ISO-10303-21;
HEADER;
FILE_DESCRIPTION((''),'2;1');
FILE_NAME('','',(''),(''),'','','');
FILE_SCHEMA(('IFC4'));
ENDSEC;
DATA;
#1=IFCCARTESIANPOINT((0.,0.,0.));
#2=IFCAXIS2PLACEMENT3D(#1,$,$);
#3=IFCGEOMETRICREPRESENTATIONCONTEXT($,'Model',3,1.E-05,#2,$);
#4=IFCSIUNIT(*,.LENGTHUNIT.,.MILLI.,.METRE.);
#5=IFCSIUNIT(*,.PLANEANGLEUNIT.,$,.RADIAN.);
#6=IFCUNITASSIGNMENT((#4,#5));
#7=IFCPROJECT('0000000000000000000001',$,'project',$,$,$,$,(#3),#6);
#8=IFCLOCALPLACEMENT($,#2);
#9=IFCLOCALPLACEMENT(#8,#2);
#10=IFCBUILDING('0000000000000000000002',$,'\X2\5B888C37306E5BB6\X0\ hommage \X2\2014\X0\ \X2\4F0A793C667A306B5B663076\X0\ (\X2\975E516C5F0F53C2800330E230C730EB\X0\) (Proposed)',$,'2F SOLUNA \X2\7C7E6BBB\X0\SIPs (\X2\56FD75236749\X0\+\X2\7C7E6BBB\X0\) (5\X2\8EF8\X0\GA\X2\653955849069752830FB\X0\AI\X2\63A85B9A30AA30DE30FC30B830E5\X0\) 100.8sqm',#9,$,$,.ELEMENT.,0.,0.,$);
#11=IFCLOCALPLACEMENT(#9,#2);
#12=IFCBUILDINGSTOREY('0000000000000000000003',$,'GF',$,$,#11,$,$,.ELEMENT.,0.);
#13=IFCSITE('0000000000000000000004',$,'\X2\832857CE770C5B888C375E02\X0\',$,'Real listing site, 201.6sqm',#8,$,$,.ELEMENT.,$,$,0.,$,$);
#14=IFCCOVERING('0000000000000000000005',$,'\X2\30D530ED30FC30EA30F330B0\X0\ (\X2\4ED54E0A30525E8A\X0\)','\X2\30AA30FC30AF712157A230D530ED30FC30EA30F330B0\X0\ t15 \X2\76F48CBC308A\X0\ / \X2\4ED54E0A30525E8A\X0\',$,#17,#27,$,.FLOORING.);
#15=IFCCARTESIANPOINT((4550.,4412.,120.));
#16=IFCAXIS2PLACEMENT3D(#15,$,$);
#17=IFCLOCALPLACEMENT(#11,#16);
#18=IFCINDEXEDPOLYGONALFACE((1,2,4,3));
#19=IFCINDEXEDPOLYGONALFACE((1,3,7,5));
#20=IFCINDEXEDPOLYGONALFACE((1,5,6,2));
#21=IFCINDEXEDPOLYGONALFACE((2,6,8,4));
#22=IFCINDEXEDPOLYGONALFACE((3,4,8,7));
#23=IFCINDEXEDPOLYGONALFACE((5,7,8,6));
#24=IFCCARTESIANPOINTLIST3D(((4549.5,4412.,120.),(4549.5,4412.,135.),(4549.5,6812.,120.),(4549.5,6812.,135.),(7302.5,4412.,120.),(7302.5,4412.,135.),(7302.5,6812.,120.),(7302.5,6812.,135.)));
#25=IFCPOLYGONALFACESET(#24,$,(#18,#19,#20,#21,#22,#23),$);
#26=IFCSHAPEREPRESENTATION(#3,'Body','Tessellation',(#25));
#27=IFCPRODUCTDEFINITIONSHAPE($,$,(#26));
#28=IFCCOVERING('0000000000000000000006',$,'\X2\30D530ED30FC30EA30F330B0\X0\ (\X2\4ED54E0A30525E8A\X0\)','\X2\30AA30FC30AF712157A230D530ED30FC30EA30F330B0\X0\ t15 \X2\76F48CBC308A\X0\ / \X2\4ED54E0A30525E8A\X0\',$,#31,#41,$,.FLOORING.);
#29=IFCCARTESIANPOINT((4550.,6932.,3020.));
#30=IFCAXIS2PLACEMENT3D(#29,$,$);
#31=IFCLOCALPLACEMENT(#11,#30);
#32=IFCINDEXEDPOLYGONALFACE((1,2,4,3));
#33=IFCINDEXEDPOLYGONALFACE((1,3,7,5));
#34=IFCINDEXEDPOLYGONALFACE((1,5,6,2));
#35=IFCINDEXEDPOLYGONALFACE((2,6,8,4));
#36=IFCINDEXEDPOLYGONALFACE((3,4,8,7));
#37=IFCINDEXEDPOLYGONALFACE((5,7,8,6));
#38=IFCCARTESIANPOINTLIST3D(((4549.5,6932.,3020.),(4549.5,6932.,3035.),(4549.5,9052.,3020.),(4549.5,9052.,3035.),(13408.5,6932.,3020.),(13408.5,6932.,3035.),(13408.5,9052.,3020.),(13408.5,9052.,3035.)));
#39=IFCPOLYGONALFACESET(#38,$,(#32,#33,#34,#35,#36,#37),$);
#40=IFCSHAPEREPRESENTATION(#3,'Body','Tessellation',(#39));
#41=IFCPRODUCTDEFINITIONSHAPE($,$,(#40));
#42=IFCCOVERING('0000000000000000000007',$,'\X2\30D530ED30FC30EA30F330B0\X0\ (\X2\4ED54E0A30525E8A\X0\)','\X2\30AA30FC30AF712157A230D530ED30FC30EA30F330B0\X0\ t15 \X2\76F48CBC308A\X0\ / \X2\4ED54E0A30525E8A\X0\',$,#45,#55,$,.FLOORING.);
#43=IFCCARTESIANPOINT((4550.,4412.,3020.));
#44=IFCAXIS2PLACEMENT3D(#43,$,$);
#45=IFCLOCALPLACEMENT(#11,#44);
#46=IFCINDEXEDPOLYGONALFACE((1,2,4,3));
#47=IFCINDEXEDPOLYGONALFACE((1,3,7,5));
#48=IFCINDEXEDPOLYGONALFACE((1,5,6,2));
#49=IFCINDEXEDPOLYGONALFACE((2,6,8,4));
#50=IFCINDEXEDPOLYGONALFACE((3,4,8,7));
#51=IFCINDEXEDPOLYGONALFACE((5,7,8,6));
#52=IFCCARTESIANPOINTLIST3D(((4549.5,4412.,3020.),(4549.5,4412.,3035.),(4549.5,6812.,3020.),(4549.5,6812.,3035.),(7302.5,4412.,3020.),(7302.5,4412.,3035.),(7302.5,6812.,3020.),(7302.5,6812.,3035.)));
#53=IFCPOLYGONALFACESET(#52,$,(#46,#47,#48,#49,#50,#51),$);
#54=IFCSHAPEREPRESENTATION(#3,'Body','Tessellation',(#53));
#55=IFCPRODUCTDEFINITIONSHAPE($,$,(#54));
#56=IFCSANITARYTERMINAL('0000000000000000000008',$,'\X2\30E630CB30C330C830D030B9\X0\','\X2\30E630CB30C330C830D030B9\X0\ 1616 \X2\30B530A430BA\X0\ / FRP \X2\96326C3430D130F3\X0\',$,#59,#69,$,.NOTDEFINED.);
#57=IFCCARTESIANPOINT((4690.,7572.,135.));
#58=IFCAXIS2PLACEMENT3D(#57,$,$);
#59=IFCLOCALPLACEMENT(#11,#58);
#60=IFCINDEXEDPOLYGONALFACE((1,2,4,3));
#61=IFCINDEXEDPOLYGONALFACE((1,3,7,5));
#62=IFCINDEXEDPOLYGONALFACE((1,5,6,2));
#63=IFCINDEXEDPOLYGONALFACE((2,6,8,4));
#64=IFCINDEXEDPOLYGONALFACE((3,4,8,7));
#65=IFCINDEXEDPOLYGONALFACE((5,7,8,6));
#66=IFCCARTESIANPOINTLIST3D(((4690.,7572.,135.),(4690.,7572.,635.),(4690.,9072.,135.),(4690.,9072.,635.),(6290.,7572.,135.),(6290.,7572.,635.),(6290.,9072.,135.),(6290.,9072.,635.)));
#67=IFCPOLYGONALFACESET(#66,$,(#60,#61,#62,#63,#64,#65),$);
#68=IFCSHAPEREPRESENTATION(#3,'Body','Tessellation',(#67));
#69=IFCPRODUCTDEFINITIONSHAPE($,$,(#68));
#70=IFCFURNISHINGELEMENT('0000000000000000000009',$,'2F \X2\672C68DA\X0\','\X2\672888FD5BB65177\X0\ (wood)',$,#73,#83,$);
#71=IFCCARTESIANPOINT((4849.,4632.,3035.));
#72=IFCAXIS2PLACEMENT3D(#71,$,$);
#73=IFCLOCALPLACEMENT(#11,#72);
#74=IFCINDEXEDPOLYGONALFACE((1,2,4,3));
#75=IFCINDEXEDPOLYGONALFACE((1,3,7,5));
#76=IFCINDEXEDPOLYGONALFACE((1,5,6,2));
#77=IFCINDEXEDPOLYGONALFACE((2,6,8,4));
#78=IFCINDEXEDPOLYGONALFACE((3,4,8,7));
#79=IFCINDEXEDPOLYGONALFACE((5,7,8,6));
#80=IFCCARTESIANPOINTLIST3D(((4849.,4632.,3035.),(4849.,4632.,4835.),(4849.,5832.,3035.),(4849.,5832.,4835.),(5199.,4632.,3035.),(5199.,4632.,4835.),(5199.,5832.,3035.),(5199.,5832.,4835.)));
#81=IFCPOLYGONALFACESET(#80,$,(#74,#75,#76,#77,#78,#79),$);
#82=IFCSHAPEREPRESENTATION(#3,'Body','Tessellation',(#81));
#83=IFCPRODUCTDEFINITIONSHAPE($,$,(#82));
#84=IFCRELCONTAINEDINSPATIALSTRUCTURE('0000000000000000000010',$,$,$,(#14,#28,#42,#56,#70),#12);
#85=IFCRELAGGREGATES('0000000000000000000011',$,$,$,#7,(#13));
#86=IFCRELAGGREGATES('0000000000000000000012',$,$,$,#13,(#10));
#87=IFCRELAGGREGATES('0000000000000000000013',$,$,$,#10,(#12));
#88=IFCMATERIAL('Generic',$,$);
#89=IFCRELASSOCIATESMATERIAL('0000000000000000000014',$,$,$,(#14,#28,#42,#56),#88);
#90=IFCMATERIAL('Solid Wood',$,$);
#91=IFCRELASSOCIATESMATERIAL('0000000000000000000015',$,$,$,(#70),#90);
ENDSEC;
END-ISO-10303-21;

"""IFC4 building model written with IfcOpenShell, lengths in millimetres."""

from ifc_helpers import new_model, si_unit, frame, frame_2d, origin, place, context, project, spatial, rectangle, extrude, material, element, save


model = new_model("IFC4")

# Units and contexts
model_context = context("Model", 3, precision=1e-05, world=origin())
ifc_project = project(units=[si_unit("LENGTHUNIT", "METRE", prefix="MILLI"), si_unit("PLANEANGLEUNIT", "RADIAN")], contexts=[model_context])

# Site, building, storey
site_placement = place(None, origin())
site = spatial("IfcSite", under=ifc_project, at=site_placement, Name="茨城県守谷市", ObjectType="Real listing site, 201.6sqm", CompositionType="ELEMENT", RefElevation=0.0)
building_placement = place(site_placement, origin())
building = spatial("IfcBuilding", under=site, at=building_placement, Name="守谷の家 hommage — 伊礼智に学ぶ (非公式参考モデル) (Proposed)", ObjectType="2F SOLUNA 籾殻SIPs (国産杉+籾殻) (5軸GA改善適用・AI推定オマージュ) 100.8sqm", CompositionType="ELEMENT", ElevationOfRefHeight=0.0, ElevationOfTerrain=0.0)
storey_placement = place(building_placement, origin())
storey = spatial("IfcBuildingStorey", under=building, at=storey_placement, Name="GF", CompositionType="ELEMENT", Elevation=0.0)

# Shared definitions
ifc_material_1 = material(Name="Solid Wood")

# Coverings
ifc_material_2 = material(Name="Generic")
covering_1_placement = place(storey_placement, frame((4550.0, 4412.0, 120.0)))
element("IfcCovering", 1, at=covering_1_placement, inside=storey, material=ifc_material_2, Name="フローリング (仕上げ床)", Description="オーク無垢フローリング t15 直貼り / 仕上げ床", PredefinedType="FLOORING", context=model_context, shape_type="SweptSolid", body=[
    extrude(rectangle(XDim=2753.0, YDim=2400.0, at=frame_2d((1376.0, 1200.0))), frame((4550.0, 4412.0, 120.0)), (0.0, 0.0, 1.0), 15.0),
])
covering_2_placement = place(storey_placement, frame((4550.0, 6932.0, 3020.0)))
element("IfcCovering", 2, at=covering_2_placement, inside=storey, material=ifc_material_2, Name="フローリング (仕上げ床)", Description="オーク無垢フローリング t15 直貼り / 仕上げ床", PredefinedType="FLOORING", context=model_context, shape_type="SweptSolid", body=[
    extrude(rectangle(XDim=8859.0, YDim=2120.0, at=frame_2d((4429.0, 1060.0))), frame((4550.0, 6932.0, 3020.0)), (0.0, 0.0, 1.0), 15.0),
])
covering_3_placement = place(storey_placement, frame((4550.0, 4412.0, 3020.0)))
element("IfcCovering", 3, at=covering_3_placement, inside=storey, material=ifc_material_2, Name="フローリング (仕上げ床)", Description="オーク無垢フローリング t15 直貼り / 仕上げ床", PredefinedType="FLOORING", context=model_context, shape_type="SweptSolid", body=[
    extrude(rectangle(XDim=2753.0, YDim=2400.0, at=frame_2d((1376.0, 1200.0))), frame((4550.0, 4412.0, 3020.0)), (0.0, 0.0, 1.0), 15.0),
])

# Sanitary terminal
sanitary_terminal_placement = place(storey_placement, frame((4690.0, 7572.0, 135.0)))
element("IfcSanitaryTerminal", 4, at=sanitary_terminal_placement, inside=storey, material=ifc_material_2, Name="ユニットバス", Description="ユニットバス 1616 サイズ / FRP 防水パン", PredefinedType="NOTDEFINED", context=model_context, shape_type="SweptSolid", body=[
    extrude(rectangle(XDim=1600.0, YDim=1500.0, at=frame_2d((800.0, 750.0))), frame((4690.0, 7572.0, 135.0)), (0.0, 0.0, 1.0), 500.0),
])

# Furnishing element
furnishing_placement = place(storey_placement, frame((4849.0, 4632.0, 3035.0)))
element("IfcFurnishingElement", 5, at=furnishing_placement, inside=storey, material=ifc_material_1, Name="2F 本棚", Description="木製家具 (wood)", context=model_context, shape_type="SweptSolid", body=[
    extrude(rectangle(XDim=350.0, YDim=1200.0, at=frame_2d((175.0, 600.0))), frame((4849.0, 4632.0, 3035.0)), (0.0, 0.0, 1.0), 1800.0),
])

save(model, "model.ifc")
